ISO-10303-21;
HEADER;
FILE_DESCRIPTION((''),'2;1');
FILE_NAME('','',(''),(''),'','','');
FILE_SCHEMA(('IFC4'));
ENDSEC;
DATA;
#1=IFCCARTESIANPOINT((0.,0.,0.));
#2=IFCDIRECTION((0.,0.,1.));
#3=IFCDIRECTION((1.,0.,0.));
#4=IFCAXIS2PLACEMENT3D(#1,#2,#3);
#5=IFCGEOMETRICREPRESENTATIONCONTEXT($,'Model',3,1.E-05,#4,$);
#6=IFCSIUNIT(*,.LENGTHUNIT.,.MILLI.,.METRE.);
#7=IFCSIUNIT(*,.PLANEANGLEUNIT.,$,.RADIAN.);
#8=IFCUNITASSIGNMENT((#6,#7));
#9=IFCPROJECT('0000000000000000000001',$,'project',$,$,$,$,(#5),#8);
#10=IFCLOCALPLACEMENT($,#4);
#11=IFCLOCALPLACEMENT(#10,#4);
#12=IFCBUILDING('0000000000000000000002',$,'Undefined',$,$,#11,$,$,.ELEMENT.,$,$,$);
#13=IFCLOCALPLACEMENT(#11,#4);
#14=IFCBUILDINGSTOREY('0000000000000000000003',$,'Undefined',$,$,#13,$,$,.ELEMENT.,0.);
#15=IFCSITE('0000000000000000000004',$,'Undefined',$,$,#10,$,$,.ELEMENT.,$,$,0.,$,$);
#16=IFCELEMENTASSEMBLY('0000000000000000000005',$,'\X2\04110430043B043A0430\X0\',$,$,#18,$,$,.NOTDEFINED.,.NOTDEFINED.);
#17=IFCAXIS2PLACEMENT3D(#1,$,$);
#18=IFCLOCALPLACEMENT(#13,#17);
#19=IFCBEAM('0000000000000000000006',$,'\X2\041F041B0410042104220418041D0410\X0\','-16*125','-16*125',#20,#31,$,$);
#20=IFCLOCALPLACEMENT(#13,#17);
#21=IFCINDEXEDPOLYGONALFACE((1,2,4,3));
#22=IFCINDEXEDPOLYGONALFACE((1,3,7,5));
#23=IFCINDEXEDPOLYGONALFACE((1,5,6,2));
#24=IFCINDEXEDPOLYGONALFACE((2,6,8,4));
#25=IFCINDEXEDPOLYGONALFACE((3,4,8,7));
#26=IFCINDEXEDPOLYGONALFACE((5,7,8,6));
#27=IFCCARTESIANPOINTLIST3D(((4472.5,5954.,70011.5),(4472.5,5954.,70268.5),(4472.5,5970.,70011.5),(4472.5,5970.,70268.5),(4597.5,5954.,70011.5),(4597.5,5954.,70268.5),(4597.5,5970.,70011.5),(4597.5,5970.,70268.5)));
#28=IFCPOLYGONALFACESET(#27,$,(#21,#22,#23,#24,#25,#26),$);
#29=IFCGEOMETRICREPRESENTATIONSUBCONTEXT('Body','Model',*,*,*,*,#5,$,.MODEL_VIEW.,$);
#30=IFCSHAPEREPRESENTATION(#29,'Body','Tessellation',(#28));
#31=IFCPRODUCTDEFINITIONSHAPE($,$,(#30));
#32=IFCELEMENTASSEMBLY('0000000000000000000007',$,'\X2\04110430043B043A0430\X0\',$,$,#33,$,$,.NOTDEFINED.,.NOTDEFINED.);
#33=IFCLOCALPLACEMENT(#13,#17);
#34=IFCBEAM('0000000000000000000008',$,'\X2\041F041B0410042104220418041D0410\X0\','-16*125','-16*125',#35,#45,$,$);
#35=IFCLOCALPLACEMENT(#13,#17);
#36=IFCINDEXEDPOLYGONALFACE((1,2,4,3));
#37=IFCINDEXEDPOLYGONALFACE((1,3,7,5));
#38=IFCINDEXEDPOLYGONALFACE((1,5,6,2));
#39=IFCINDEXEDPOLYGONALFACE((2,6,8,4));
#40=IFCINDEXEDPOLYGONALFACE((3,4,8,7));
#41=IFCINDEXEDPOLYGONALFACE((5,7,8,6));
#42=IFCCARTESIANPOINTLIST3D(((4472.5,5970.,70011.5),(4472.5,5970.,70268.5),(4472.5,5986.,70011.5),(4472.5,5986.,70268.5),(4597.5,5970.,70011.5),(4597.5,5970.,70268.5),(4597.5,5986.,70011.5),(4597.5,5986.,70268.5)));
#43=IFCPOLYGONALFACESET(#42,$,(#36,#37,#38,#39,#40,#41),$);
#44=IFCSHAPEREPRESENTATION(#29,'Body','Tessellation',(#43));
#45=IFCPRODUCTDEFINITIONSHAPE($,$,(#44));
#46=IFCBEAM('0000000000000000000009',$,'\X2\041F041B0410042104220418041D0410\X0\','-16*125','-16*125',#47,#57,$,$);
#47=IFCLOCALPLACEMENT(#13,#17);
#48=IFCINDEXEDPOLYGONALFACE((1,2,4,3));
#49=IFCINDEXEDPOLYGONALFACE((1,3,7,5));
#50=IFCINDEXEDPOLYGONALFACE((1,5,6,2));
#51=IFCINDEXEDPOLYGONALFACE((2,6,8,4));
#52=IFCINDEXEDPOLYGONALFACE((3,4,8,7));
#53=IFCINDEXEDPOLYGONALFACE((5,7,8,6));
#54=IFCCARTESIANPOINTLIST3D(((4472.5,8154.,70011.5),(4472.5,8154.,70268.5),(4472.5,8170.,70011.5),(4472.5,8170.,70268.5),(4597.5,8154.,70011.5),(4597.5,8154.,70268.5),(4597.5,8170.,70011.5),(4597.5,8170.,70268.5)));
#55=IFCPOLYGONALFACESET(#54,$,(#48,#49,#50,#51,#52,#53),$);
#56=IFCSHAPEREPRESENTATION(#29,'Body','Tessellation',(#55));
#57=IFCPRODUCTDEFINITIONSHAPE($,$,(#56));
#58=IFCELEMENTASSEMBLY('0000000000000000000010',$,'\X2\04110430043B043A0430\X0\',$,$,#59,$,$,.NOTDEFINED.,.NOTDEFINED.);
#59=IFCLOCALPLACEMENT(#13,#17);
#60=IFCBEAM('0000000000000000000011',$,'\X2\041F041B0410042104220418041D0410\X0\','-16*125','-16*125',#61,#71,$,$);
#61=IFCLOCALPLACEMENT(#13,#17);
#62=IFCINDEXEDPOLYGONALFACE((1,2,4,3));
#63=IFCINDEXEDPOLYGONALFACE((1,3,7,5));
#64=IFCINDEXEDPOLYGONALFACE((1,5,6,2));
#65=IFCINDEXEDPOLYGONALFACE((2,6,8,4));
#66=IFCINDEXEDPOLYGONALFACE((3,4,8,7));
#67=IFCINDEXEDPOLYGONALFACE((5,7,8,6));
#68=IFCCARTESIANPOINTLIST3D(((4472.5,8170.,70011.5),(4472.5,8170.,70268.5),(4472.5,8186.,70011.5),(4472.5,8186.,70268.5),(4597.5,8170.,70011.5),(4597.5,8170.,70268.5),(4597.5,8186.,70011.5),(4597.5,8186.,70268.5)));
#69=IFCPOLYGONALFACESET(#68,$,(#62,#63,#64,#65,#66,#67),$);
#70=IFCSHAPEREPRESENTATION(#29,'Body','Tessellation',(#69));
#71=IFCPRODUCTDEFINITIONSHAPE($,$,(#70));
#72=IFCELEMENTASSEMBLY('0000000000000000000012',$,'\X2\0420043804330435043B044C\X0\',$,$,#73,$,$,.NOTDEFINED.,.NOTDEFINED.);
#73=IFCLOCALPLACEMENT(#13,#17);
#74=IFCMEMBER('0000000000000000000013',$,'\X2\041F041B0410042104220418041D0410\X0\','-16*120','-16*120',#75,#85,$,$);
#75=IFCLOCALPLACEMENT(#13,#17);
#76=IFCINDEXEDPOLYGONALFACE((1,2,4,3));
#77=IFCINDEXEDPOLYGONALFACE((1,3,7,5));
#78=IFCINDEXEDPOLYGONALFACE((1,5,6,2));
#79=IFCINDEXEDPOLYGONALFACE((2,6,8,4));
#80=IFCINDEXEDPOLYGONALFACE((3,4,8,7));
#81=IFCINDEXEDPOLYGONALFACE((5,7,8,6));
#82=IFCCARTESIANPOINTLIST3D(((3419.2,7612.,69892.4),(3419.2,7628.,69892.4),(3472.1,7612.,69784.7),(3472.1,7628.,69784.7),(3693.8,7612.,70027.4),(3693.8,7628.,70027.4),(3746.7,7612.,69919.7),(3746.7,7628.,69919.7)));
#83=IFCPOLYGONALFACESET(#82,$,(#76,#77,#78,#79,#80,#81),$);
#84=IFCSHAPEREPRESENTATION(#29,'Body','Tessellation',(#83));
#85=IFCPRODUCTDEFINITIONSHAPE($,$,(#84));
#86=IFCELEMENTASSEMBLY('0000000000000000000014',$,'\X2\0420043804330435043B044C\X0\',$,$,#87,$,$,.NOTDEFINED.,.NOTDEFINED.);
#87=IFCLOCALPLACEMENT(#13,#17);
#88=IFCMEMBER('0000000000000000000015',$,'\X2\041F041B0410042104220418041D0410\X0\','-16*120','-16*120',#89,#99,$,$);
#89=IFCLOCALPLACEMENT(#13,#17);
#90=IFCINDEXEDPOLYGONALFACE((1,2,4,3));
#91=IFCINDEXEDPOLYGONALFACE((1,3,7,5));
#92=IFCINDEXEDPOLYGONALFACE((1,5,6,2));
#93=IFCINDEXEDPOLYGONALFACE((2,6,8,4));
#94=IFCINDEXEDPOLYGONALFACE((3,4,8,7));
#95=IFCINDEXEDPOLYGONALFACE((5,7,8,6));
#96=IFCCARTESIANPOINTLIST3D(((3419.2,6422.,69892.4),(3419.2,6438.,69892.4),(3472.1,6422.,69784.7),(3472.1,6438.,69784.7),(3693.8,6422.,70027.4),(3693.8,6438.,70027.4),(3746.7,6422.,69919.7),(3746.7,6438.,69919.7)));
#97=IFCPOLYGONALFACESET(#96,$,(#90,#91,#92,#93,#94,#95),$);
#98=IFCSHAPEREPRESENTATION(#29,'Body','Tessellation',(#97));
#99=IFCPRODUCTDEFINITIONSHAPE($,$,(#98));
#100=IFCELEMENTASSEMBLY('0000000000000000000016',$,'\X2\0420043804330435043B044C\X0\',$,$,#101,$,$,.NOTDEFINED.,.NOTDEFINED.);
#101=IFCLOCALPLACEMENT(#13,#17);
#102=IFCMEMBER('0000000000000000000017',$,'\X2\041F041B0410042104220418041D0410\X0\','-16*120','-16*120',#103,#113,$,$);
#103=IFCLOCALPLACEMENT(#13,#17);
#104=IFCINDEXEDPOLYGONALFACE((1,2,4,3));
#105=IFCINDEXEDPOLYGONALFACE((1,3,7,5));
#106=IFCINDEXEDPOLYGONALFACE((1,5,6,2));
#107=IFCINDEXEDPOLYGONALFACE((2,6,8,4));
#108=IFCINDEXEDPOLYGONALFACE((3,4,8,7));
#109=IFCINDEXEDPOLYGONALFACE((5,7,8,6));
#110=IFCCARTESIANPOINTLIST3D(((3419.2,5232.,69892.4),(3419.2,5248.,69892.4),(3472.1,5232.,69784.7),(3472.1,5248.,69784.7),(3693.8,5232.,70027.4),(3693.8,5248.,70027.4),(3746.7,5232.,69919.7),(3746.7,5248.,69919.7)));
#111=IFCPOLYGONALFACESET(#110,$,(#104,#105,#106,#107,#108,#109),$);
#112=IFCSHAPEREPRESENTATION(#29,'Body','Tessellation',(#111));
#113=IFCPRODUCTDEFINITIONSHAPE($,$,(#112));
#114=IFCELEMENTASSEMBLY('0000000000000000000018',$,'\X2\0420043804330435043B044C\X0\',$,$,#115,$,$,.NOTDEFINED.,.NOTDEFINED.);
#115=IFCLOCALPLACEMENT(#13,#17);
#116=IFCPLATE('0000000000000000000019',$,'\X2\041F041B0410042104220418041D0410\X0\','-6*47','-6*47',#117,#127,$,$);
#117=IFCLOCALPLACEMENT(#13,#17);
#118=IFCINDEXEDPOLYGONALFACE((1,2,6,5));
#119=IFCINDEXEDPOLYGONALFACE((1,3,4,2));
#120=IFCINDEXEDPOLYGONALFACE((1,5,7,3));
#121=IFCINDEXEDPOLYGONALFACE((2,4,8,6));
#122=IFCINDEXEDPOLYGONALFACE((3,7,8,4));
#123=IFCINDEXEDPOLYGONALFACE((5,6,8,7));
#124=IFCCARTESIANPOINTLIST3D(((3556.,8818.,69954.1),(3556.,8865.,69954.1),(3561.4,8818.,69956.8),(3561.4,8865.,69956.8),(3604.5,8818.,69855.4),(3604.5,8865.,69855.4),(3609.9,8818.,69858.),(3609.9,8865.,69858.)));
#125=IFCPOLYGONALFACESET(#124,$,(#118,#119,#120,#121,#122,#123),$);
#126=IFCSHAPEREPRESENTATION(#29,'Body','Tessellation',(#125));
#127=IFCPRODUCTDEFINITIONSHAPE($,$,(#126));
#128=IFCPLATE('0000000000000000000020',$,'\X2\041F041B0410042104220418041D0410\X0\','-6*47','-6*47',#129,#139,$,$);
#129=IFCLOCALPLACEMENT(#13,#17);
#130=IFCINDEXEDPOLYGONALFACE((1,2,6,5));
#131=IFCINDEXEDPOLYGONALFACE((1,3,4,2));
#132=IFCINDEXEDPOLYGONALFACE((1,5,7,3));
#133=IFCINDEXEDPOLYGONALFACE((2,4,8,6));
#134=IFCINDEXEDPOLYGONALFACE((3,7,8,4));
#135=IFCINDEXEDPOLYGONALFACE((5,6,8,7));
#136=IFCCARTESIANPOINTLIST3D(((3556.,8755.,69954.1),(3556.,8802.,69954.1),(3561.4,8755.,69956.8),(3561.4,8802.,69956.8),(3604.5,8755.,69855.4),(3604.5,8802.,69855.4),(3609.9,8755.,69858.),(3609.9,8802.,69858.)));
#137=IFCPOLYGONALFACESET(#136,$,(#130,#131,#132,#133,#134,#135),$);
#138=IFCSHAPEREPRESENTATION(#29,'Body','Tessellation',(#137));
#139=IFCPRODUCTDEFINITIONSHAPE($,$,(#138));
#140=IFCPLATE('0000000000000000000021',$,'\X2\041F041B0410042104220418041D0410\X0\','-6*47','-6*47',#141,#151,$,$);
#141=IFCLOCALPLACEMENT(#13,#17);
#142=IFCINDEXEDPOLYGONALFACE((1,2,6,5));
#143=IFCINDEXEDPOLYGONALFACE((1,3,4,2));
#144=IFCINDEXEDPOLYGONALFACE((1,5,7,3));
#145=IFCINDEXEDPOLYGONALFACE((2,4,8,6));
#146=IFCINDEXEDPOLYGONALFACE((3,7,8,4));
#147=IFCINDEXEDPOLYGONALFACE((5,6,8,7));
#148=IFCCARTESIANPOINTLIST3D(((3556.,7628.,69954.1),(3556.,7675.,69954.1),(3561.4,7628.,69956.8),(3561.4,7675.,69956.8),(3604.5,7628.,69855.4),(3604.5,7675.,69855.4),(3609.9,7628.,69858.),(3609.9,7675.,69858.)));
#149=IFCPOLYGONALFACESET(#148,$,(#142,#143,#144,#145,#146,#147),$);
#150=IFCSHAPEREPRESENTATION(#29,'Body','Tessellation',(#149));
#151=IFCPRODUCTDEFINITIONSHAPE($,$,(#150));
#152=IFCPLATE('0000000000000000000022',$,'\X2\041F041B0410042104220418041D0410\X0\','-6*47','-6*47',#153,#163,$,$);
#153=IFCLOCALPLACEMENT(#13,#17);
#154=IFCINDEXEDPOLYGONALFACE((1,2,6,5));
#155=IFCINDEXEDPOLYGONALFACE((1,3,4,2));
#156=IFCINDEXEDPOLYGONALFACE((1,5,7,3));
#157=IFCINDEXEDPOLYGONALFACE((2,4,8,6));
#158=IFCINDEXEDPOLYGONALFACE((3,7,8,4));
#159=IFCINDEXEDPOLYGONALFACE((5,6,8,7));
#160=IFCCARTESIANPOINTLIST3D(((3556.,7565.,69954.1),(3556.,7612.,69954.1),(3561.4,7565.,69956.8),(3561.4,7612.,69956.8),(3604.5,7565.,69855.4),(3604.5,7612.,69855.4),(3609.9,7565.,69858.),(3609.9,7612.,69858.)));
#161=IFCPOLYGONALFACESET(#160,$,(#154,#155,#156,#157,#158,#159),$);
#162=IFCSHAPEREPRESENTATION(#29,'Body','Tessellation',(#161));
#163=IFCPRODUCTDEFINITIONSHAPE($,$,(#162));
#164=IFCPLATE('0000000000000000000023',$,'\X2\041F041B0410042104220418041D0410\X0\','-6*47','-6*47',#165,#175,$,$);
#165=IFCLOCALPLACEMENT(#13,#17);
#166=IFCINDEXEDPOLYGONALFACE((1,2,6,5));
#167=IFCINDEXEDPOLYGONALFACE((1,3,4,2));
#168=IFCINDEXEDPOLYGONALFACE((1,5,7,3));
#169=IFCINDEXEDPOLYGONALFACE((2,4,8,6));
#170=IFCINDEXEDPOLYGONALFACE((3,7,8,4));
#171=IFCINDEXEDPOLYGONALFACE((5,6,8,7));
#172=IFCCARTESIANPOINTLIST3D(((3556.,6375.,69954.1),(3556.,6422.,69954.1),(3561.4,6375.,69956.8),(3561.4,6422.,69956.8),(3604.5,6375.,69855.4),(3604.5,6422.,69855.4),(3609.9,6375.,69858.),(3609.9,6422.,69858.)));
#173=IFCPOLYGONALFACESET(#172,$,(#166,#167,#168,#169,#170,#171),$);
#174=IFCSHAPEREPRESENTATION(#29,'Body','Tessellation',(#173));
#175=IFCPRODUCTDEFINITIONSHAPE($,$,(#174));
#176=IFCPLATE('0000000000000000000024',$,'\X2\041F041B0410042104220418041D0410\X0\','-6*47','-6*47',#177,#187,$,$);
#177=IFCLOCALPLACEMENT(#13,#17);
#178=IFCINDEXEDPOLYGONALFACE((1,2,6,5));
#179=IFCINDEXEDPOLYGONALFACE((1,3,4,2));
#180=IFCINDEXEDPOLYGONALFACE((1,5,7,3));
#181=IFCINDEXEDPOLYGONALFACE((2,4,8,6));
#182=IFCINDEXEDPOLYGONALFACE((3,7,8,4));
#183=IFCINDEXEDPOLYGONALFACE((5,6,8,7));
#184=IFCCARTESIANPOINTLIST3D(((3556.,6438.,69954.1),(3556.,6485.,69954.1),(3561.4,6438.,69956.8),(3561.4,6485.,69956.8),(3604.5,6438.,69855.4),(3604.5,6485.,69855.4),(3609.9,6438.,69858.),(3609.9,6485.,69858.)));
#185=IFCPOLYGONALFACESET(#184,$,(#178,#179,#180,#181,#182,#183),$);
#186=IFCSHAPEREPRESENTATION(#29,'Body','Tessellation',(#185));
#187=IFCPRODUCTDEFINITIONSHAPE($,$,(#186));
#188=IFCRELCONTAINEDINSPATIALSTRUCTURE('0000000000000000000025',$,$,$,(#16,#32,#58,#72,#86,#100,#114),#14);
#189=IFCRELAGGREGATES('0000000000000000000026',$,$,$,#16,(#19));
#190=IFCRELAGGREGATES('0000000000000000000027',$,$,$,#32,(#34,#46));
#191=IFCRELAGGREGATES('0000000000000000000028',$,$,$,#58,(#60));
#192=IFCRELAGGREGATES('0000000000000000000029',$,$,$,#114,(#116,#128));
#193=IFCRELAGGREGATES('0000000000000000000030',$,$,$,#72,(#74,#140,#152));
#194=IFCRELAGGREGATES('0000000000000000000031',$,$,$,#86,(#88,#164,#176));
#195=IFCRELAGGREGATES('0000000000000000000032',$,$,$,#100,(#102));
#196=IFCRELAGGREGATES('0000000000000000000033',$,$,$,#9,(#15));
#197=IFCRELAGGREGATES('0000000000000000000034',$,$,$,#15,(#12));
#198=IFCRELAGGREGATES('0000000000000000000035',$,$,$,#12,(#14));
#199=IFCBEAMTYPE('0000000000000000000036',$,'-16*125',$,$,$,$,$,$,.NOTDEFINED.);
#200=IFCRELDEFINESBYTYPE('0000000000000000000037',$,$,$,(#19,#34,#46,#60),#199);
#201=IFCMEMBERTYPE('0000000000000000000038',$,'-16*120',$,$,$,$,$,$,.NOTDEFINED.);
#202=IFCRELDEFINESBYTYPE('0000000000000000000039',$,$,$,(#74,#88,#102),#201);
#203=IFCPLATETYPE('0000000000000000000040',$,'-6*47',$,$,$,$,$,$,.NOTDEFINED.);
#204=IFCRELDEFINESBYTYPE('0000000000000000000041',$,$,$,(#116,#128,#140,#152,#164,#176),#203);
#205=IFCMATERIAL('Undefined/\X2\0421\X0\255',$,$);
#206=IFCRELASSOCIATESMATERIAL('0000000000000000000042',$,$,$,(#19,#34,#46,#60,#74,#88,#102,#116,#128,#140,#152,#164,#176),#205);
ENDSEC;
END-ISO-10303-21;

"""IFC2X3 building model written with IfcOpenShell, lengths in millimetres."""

from ifc_helpers import new_model, si_unit, frame, origin_with_axes, origin_2d_with_axis, place, context, subcontext, project, spatial, polyline, rectangle, outline, extrude, boolean, material, type_object, element, aggregate, save


model = new_model("IFC2X3")

# Units and contexts
model_context = context("Model", 3, precision=1e-05, world=origin_with_axes())
body_context = subcontext(model_context, "Body", "Model", "MODEL_VIEW")
ifc_project = project(units=[si_unit("LENGTHUNIT", "METRE", prefix="MILLI"), si_unit("PLANEANGLEUNIT", "RADIAN")], contexts=[model_context])

# Site, building, storey
site_placement = place(None, origin_with_axes())
site = spatial("IfcSite", under=ifc_project, at=site_placement, Name="Undefined", CompositionType="ELEMENT", RefElevation=0.0)
building_placement = place(site_placement, origin_with_axes())
building = spatial("IfcBuilding", under=site, at=building_placement, Name="Undefined", CompositionType="ELEMENT")
storey_placement = place(building_placement, origin_with_axes())
storey = spatial("IfcBuildingStorey", under=building, at=storey_placement, Name="Undefined", CompositionType="ELEMENT", Elevation=0.0)

# Element assembly, beam
assembly_1_placement = place(storey_placement, origin_with_axes())
assembly_1 = element("IfcElementAssembly", 1, at=assembly_1_placement, inside=storey, Name="Балка", AssemblyPlace="NOTDEFINED", PredefinedType="NOTDEFINED")
ifc_material_1 = material(Name="Undefined/С255")
beam_type = type_object("IfcBeamType", Name="-16*125", PredefinedType="NOTDEFINED")
beam_1_placement = place(assembly_1_placement, frame((4535.0, 5962.0, 70011.5), z_axis=(-1.0, 0.0, 0.0), x_axis=(0.0, 0.0, 1.0)))
beam_1 = element("IfcBeam", 2, at=beam_1_placement, type_object=beam_type, material=ifc_material_1, Name="ПЛАСТИНА", Description="-16*125", ObjectType="-16*125", context=body_context, shape_type="SweptSolid", body=[
    extrude(rectangle(XDim=16.0, YDim=125.0, at=origin_2d_with_axis()), frame((257.0, 0.0, 0.0), z_axis=(-1.0, 0.0, 0.0), x_axis=(0.0, -1.0, 0.0)), (0.0, 0.0, 1.0), 257.0),
])
aggregate(assembly_1, [beam_1])

# Element assembly, beams
assembly_2_placement = place(storey_placement, origin_with_axes())
assembly_2 = element("IfcElementAssembly", 3, at=assembly_2_placement, inside=storey, Name="Балка", AssemblyPlace="NOTDEFINED", PredefinedType="NOTDEFINED")
beam_2_placement = place(assembly_2_placement, frame((4535.0, 5978.0, 70011.5), z_axis=(-1.0, 0.0, 0.0), x_axis=(0.0, 0.0, 1.0)))
beam_2 = element("IfcBeam", 4, at=beam_2_placement, type_object=beam_type, material=ifc_material_1, Name="ПЛАСТИНА", Description="-16*125", ObjectType="-16*125", context=body_context, shape_type="SweptSolid", body=[
    extrude(rectangle(XDim=16.0, YDim=125.0, at=origin_2d_with_axis()), frame((257.0, 0.0, 0.0), z_axis=(-1.0, 0.0, 0.0), x_axis=(0.0, -1.0, 0.0)), (0.0, 0.0, 1.0), 257.0),
])
beam_3_placement = place(assembly_2_placement, frame((4535.0, 8162.0, 70011.5), z_axis=(-1.0, 0.0, 0.0), x_axis=(0.0, 0.0, 1.0)))
beam_3 = element("IfcBeam", 5, at=beam_3_placement, type_object=beam_type, material=ifc_material_1, Name="ПЛАСТИНА", Description="-16*125", ObjectType="-16*125", context=body_context, shape_type="SweptSolid", body=[
    extrude(rectangle(XDim=16.0, YDim=125.0, at=origin_2d_with_axis()), frame((257.0, 0.0, 0.0), z_axis=(-1.0, 0.0, 0.0), x_axis=(0.0, -1.0, 0.0)), (0.0, 0.0, 1.0), 257.0),
])
aggregate(assembly_2, [beam_2, beam_3])

# Element assembly, beam
assembly_3_placement = place(storey_placement, origin_with_axes())
assembly_3 = element("IfcElementAssembly", 6, at=assembly_3_placement, inside=storey, Name="Балка", AssemblyPlace="NOTDEFINED", PredefinedType="NOTDEFINED")
beam_4_placement = place(assembly_3_placement, frame((4535.0, 8178.0, 70011.5), z_axis=(-1.0, 0.0, 0.0), x_axis=(0.0, 0.0, 1.0)))
beam_4 = element("IfcBeam", 7, at=beam_4_placement, type_object=beam_type, material=ifc_material_1, Name="ПЛАСТИНА", Description="-16*125", ObjectType="-16*125", context=body_context, shape_type="SweptSolid", body=[
    extrude(rectangle(XDim=16.0, YDim=125.0, at=origin_2d_with_axis()), frame((257.0, 0.0, 0.0), z_axis=(-1.0, 0.0, 0.0), x_axis=(0.0, -1.0, 0.0)), (0.0, 0.0, 1.0), 257.0),
])
aggregate(assembly_3, [beam_4])

# Element assemblies, members
assembly_4_placement = place(storey_placement, origin_with_axes())
assembly_4 = element("IfcElementAssembly", 8, at=assembly_4_placement, inside=storey, Name="Ригель", AssemblyPlace="NOTDEFINED", PredefinedType="NOTDEFINED")
member_type = type_object("IfcMemberType", Name="-16*120", PredefinedType="NOTDEFINED")
member_1_placement = place(assembly_4_placement, frame((3445.7, 7620.0, 69838.6), z_axis=(0.441221, 0.0, -0.897399), x_axis=(0.897399, 0.0, 0.441221)))
member_1 = element("IfcMember", 9, at=member_1_placement, type_object=member_type, material=ifc_material_1, Name="ПЛАСТИНА", Description="-16*120", ObjectType="-16*120", context=body_context, shape_type="SweptSolid", body=[
    extrude(rectangle(XDim=16.0, YDim=120.0, at=origin_2d_with_axis()), frame((306.0, 0.0, 0.0), z_axis=(-1.0, 0.0, 0.0), x_axis=(0.0, -1.0, 0.0)), (0.0, 0.0, 1.0), 306.0),
])
assembly_5_placement = place(storey_placement, origin_with_axes())
assembly_5 = element("IfcElementAssembly", 10, at=assembly_5_placement, inside=storey, Name="Ригель", AssemblyPlace="NOTDEFINED", PredefinedType="NOTDEFINED")
member_2_placement = place(assembly_5_placement, frame((3445.7, 6430.0, 69838.6), z_axis=(0.441221, 0.0, -0.897399), x_axis=(0.897399, 0.0, 0.441221)))
member_2 = element("IfcMember", 11, at=member_2_placement, type_object=member_type, material=ifc_material_1, Name="ПЛАСТИНА", Description="-16*120", ObjectType="-16*120", context=body_context, shape_type="SweptSolid", body=[
    extrude(rectangle(XDim=16.0, YDim=120.0, at=origin_2d_with_axis()), frame((306.0, 0.0, 0.0), z_axis=(-1.0, 0.0, 0.0), x_axis=(0.0, -1.0, 0.0)), (0.0, 0.0, 1.0), 306.0),
])
assembly_6_placement = place(storey_placement, origin_with_axes())
assembly_6 = element("IfcElementAssembly", 12, at=assembly_6_placement, inside=storey, Name="Ригель", AssemblyPlace="NOTDEFINED", PredefinedType="NOTDEFINED")
member_3_placement = place(assembly_6_placement, frame((3445.7, 5240.0, 69838.6), z_axis=(0.441221, 0.0, -0.897399), x_axis=(0.897399, 0.0, 0.441221)))
member_3 = element("IfcMember", 13, at=member_3_placement, type_object=member_type, material=ifc_material_1, Name="ПЛАСТИНА", Description="-16*120", ObjectType="-16*120", context=body_context, shape_type="SweptSolid", body=[
    extrude(rectangle(XDim=16.0, YDim=120.0, at=origin_2d_with_axis()), frame((306.0, 0.0, 0.0), z_axis=(-1.0, 0.0, 0.0), x_axis=(0.0, -1.0, 0.0)), (0.0, 0.0, 1.0), 306.0),
])

# Element assembly, plates
assembly_7_placement = place(storey_placement, origin_with_axes())
assembly_7 = element("IfcElementAssembly", 14, at=assembly_7_placement, inside=storey, Name="Ригель", AssemblyPlace="NOTDEFINED", PredefinedType="NOTDEFINED")
plate_type = type_object("IfcPlateType", Name="-6*47", PredefinedType="NOTDEFINED")
plate_1_placement = place(assembly_7_placement, frame((3607.2, 8755.0, 69856.7), z_axis=(-0.897399, 0.0, -0.441221), x_axis=(-0.441221, 0.0, 0.897399)))
plate_1 = element("IfcPlate", 15, at=plate_1_placement, type_object=plate_type, material=ifc_material_1, Name="ПЛАСТИНА", Description="-6*47", ObjectType="-6*47", context=body_context, shape_type="CSG", body=[
    boolean("DIFFERENCE", extrude(outline(polyline([(0.0, 0.0), (110.0, 0.0), (110.0, 110.0), (0.0, 110.0), (0.0, 0.0)])), frame((0.0, 0.0, -3.0), z_axis=(0.0, 0.0, 1.0), x_axis=(1.0, 0.0, 0.0)), (0.0, 0.0, 1.0), 6.0), extrude(rectangle(XDim=26.0, YDim=130.0, at=origin_2d_with_axis()), frame((55.0, -3.0, 0.0), z_axis=(0.0, 1.0, 0.0), x_axis=(0.0, 0.0, -1.0)), (0.0, 0.0, 1.0), 66.0)),
])
plate_2_placement = place(assembly_7_placement, frame((3607.2, 8755.0, 69856.7), z_axis=(-0.897399, 0.0, -0.441221), x_axis=(-0.441221, 0.0, 0.897399)))
plate_2 = element("IfcPlate", 16, at=plate_2_placement, type_object=plate_type, material=ifc_material_1, Name="ПЛАСТИНА", Description="-6*47", ObjectType="-6*47", context=body_context, shape_type="CSG", body=[
    boolean("DIFFERENCE", extrude(outline(polyline([(0.0, 0.0), (110.0, 0.0), (110.0, 110.0), (0.0, 110.0), (0.0, 0.0)])), frame((0.0, 0.0, -3.0), z_axis=(0.0, 0.0, 1.0), x_axis=(1.0, 0.0, 0.0)), (0.0, 0.0, 1.0), 6.0), extrude(rectangle(XDim=26.0, YDim=130.0, at=origin_2d_with_axis()), frame((55.0, 47.0, 0.0), z_axis=(0.0, 1.0, 0.0), x_axis=(0.0, 0.0, -1.0)), (0.0, 0.0, 1.0), 66.0)),
])
aggregate(assembly_7, [plate_1, plate_2])

# Plates
plate_3_placement = place(assembly_4_placement, frame((3607.2, 7565.0, 69856.7), z_axis=(-0.897399, 0.0, -0.441221), x_axis=(-0.441221, 0.0, 0.897399)))
plate_3 = element("IfcPlate", 17, at=plate_3_placement, type_object=plate_type, material=ifc_material_1, Name="ПЛАСТИНА", Description="-6*47", ObjectType="-6*47", context=body_context, shape_type="CSG", body=[
    boolean("DIFFERENCE", extrude(outline(polyline([(0.0, 0.0), (110.0, 0.0), (110.0, 110.0), (0.0, 110.0), (0.0, 0.0)])), frame((0.0, 0.0, -3.0), z_axis=(0.0, 0.0, 1.0), x_axis=(1.0, 0.0, 0.0)), (0.0, 0.0, 1.0), 6.0), extrude(rectangle(XDim=26.0, YDim=130.0, at=origin_2d_with_axis()), frame((55.0, -3.0, 0.0), z_axis=(0.0, 1.0, 0.0), x_axis=(0.0, 0.0, -1.0)), (0.0, 0.0, 1.0), 66.0)),
])
plate_4_placement = place(assembly_4_placement, frame((3607.2, 7565.0, 69856.7), z_axis=(-0.897399, 0.0, -0.441221), x_axis=(-0.441221, 0.0, 0.897399)))
plate_4 = element("IfcPlate", 18, at=plate_4_placement, type_object=plate_type, material=ifc_material_1, Name="ПЛАСТИНА", Description="-6*47", ObjectType="-6*47", context=body_context, shape_type="CSG", body=[
    boolean("DIFFERENCE", extrude(outline(polyline([(0.0, 0.0), (110.0, 0.0), (110.0, 110.0), (0.0, 110.0), (0.0, 0.0)])), frame((0.0, 0.0, -3.0), z_axis=(0.0, 0.0, 1.0), x_axis=(1.0, 0.0, 0.0)), (0.0, 0.0, 1.0), 6.0), extrude(rectangle(XDim=26.0, YDim=130.0, at=origin_2d_with_axis()), frame((55.0, 47.0, 0.0), z_axis=(0.0, 1.0, 0.0), x_axis=(0.0, 0.0, -1.0)), (0.0, 0.0, 1.0), 66.0)),
])
plate_5_placement = place(assembly_5_placement, frame((3607.2, 6375.0, 69856.7), z_axis=(-0.897399, 0.0, -0.441221), x_axis=(-0.441221, 0.0, 0.897399)))
plate_5 = element("IfcPlate", 19, at=plate_5_placement, type_object=plate_type, material=ifc_material_1, Name="ПЛАСТИНА", Description="-6*47", ObjectType="-6*47", context=body_context, shape_type="CSG", body=[
    boolean("DIFFERENCE", extrude(outline(polyline([(0.0, 0.0), (110.0, 0.0), (110.0, 110.0), (0.0, 110.0), (0.0, 0.0)])), frame((0.0, 0.0, -3.0), z_axis=(0.0, 0.0, 1.0), x_axis=(1.0, 0.0, 0.0)), (0.0, 0.0, 1.0), 6.0), extrude(rectangle(XDim=26.0, YDim=130.0, at=origin_2d_with_axis()), frame((55.0, 47.0, 0.0), z_axis=(0.0, 1.0, 0.0), x_axis=(0.0, 0.0, -1.0)), (0.0, 0.0, 1.0), 66.0)),
])
plate_6_placement = place(assembly_5_placement, frame((3607.2, 6375.0, 69856.7), z_axis=(-0.897399, 0.0, -0.441221), x_axis=(-0.441221, 0.0, 0.897399)))
plate_6 = element("IfcPlate", 20, at=plate_6_placement, type_object=plate_type, material=ifc_material_1, Name="ПЛАСТИНА", Description="-6*47", ObjectType="-6*47", context=body_context, shape_type="CSG", body=[
    boolean("DIFFERENCE", extrude(outline(polyline([(0.0, 0.0), (110.0, 0.0), (110.0, 110.0), (0.0, 110.0), (0.0, 0.0)])), frame((0.0, 0.0, -3.0), z_axis=(0.0, 0.0, 1.0), x_axis=(1.0, 0.0, 0.0)), (0.0, 0.0, 1.0), 6.0), extrude(rectangle(XDim=26.0, YDim=130.0, at=origin_2d_with_axis()), frame((55.0, -3.0, 0.0), z_axis=(0.0, 1.0, 0.0), x_axis=(0.0, 0.0, -1.0)), (0.0, 0.0, 1.0), 66.0)),
])

aggregate(assembly_4, [member_1, plate_3, plate_4])
aggregate(assembly_5, [member_2, plate_5, plate_6])
aggregate(assembly_6, [member_3])

save(model, "model.ifc")
